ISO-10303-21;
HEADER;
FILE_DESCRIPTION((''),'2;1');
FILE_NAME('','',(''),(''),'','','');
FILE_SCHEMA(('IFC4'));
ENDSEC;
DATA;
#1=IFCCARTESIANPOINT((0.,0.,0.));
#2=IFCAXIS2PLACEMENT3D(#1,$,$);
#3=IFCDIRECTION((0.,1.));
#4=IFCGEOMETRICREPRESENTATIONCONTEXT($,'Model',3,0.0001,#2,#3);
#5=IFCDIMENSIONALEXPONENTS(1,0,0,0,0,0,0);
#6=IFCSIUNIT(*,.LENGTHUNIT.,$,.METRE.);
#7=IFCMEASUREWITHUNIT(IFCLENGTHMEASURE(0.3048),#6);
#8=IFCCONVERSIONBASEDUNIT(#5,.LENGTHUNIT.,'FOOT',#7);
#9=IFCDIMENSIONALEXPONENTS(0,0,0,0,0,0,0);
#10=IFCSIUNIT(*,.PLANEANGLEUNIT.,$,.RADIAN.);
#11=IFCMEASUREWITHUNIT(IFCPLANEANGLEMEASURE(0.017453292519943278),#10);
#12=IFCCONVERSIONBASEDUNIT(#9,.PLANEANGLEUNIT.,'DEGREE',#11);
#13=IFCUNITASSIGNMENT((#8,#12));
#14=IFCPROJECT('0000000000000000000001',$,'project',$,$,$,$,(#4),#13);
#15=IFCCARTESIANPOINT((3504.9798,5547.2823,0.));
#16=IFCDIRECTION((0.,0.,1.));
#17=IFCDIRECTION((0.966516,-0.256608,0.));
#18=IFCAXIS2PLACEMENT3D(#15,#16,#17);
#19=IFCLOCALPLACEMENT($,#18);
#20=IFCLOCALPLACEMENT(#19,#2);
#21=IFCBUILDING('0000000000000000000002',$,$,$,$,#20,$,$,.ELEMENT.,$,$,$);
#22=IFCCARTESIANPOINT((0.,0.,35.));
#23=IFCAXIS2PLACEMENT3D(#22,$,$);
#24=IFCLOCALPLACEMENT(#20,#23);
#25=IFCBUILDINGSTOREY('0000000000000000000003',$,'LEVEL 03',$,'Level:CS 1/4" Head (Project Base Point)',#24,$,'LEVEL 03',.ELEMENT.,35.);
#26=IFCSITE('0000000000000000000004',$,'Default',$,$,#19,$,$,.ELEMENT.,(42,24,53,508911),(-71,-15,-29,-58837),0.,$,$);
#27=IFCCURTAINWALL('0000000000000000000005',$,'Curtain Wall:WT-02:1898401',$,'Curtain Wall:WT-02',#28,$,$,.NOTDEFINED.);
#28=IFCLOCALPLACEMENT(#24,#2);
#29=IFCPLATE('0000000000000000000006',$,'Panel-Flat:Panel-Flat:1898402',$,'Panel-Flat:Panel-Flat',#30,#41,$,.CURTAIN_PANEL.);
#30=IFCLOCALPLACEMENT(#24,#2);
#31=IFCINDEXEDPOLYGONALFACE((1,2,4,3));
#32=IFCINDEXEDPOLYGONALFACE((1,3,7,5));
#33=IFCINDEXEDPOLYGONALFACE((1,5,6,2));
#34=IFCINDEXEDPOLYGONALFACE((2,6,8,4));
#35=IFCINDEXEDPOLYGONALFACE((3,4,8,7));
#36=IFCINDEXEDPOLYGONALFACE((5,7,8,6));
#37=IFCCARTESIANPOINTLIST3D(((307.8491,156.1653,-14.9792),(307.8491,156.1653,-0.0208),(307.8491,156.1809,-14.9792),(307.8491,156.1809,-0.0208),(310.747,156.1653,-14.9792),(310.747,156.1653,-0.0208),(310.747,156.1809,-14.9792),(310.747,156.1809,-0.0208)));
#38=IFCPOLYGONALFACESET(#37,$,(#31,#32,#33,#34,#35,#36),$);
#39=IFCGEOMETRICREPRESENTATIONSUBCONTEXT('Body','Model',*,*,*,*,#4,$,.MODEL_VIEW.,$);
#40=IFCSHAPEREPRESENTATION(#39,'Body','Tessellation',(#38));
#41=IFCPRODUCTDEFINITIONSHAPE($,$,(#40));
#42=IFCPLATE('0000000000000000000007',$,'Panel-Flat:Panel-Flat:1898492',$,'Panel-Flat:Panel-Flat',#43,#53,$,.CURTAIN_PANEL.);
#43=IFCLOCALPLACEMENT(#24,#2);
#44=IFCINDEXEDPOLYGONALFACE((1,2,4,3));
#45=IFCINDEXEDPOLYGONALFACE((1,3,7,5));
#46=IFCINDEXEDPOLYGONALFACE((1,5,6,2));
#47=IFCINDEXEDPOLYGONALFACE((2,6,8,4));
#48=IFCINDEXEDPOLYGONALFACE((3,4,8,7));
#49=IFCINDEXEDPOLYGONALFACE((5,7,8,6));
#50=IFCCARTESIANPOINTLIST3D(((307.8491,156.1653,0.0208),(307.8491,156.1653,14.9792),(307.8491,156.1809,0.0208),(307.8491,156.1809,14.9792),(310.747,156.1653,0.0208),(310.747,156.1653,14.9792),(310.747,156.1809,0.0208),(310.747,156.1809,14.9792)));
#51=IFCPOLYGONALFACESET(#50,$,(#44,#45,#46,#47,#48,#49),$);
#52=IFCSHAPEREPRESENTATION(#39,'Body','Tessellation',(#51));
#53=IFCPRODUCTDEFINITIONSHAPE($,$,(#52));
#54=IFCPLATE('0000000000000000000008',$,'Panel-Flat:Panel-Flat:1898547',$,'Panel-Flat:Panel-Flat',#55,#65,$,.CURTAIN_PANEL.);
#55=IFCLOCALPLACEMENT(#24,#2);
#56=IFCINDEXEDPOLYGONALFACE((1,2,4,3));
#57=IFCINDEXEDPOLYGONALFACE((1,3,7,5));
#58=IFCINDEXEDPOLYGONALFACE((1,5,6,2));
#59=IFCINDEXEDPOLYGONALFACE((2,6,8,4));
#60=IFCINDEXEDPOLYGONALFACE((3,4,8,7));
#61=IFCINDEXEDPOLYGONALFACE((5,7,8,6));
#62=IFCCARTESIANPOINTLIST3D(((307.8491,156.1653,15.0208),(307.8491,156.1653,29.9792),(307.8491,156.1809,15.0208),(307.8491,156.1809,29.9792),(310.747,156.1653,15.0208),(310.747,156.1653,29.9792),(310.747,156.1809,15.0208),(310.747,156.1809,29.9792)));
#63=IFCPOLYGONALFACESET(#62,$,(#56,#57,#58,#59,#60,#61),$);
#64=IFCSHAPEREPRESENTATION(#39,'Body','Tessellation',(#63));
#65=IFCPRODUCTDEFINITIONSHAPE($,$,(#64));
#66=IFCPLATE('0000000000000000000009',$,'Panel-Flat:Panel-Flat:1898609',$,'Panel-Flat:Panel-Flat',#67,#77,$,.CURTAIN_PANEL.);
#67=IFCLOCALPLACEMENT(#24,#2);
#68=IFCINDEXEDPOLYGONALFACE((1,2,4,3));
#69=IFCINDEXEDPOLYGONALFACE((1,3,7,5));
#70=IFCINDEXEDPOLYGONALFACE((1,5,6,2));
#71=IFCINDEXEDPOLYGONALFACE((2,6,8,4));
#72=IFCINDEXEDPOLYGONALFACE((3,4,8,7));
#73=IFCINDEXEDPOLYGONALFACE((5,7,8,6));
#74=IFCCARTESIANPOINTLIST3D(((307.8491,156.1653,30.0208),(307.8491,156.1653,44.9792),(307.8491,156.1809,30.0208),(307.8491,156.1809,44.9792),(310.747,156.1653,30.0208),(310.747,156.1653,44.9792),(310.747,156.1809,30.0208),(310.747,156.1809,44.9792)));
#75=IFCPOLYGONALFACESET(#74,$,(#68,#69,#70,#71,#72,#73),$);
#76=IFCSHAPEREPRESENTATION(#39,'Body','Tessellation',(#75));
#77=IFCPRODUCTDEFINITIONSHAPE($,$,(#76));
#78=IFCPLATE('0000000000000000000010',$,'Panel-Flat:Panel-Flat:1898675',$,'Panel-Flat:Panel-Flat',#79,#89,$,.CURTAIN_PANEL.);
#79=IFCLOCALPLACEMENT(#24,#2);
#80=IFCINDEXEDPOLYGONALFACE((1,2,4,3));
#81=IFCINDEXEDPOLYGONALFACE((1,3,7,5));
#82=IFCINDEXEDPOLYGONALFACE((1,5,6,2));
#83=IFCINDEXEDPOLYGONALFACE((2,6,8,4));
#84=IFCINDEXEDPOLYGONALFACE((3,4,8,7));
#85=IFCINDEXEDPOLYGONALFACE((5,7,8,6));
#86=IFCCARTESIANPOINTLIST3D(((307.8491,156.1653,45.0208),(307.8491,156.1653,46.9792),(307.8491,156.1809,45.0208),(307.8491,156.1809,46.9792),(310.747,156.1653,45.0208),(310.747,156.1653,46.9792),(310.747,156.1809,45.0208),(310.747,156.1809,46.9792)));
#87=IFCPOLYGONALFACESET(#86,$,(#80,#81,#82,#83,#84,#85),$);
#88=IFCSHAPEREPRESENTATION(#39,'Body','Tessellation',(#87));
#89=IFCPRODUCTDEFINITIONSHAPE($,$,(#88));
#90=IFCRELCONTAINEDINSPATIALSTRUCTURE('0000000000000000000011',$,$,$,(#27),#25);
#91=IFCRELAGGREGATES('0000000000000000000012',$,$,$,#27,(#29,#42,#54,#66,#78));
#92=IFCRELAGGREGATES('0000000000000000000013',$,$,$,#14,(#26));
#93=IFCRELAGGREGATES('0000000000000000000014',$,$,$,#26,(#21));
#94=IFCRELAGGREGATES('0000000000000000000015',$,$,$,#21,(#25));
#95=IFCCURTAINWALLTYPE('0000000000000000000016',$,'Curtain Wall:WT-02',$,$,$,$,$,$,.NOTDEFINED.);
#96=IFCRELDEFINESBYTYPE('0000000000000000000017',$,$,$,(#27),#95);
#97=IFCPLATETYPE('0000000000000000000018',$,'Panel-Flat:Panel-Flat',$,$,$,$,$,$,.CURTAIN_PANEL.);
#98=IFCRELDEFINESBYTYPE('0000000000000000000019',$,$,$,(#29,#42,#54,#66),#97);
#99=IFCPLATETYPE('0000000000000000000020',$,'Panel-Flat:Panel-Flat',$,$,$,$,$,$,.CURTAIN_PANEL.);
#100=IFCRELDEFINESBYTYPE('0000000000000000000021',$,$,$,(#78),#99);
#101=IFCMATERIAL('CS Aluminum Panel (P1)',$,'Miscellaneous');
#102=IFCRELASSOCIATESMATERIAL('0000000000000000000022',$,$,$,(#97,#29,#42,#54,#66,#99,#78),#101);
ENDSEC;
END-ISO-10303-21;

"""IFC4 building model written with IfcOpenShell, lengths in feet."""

from ifc_helpers import new_model, entity, si_unit, converted_unit, direction, frame, origin, place, context, subcontext, project, spatial, indexed_curve, outline, extrude, source, transform, mapped, material, type_object, type_shapes, element, aggregate, save


model = new_model("IFC4")

# Units and contexts
model_context = context("Model", 3, precision=0.0001, world=origin(), true_north=direction((0.0, 1.0)))
body_context = subcontext(model_context, "Body", "Model", "MODEL_VIEW")
ifc_project = project(units=[converted_unit("LENGTHUNIT", "FOOT", entity("IfcLengthMeasure", 0.3048), si_unit("LENGTHUNIT", "METRE"), dimensions=[1, 0, 0, 0, 0, 0, 0]), converted_unit("PLANEANGLEUNIT", "DEGREE", entity("IfcPlaneAngleMeasure", 0.017453292519943278), si_unit("PLANEANGLEUNIT", "RADIAN"), dimensions=[0, 0, 0, 0, 0, 0, 0])], contexts=[model_context])

# Site, building, storey
site_placement = place(None, frame((3504.9798, 5547.2823, 0.0), z_axis=(0.0, 0.0, 1.0), x_axis=(0.966516, -0.256608, 0.0)))
site = spatial("IfcSite", under=ifc_project, at=site_placement, Name="Default", CompositionType="ELEMENT", RefLatitude=(42, 24, 53, 508911), RefLongitude=(-71, -15, -29, -58837), RefElevation=0.0)
building_placement = place(site_placement, origin())
building = spatial("IfcBuilding", under=site, at=building_placement, CompositionType="ELEMENT")
storey_placement = place(building_placement, frame((0.0, 0.0, 35.0)))
storey = spatial("IfcBuildingStorey", under=building, at=storey_placement, Name="LEVEL 03", ObjectType="Level:CS 1/4\" Head (Project Base Point)", LongName="LEVEL 03", CompositionType="ELEMENT", Elevation=35.0)

# Curtain wall, plates
curtain_wall_type = type_object("IfcCurtainWallType", Name="Curtain Wall:WT-02", PredefinedType="NOTDEFINED")
curtain_wall_1_placement = place(storey_placement, frame((0.0, 0.0, -35.0)))
curtain_wall_1 = element("IfcCurtainWall", 1, at=curtain_wall_1_placement, inside=storey, type_object=curtain_wall_type, Name="Curtain Wall:WT-02:1898401", ObjectType="Curtain Wall:WT-02", PredefinedType="NOTDEFINED")
ifc_material_1 = material(Name="CS Aluminum Panel (P1)", Category="Miscellaneous")
plate_type_1 = type_object("IfcPlateType", Name="Panel-Flat:Panel-Flat", PredefinedType="CURTAIN_PANEL", material=ifc_material_1)
shared_shape_1 = source(origin(), body_context, "Body", "SweptSolid", [
    extrude(outline(indexed_curve([(-0.0078, -1.4489), (0.0078, -1.4489), (0.0078, 1.4489), (-0.0078, 1.4489), (-0.0078, -1.4489)], self_intersect=False)), frame((1.4489, 0.0078, 0.0), z_axis=(0.0, 0.0, 1.0), x_axis=(0.0, -1.0, 0.0)), (0.0, 0.0, 1.0), 14.9583),
])
type_shapes(plate_type_1, [shared_shape_1])
plate_1_placement = place(curtain_wall_1_placement, frame((310.747, 156.1809, 20.0208), z_axis=(0.0, 0.0, 1.0), x_axis=(-1.0, 0.0, 0.0)))
plate_1 = element("IfcPlate", 2, at=plate_1_placement, type_object=plate_type_1, material=ifc_material_1, Name="Panel-Flat:Panel-Flat:1898402", ObjectType="Panel-Flat:Panel-Flat", PredefinedType="CURTAIN_PANEL", context=body_context, shape_type="MappedRepresentation", body=[
    mapped(shared_shape_1, transform((0.0, 0.0, 0.0), scale=1.0)),
])
plate_2_placement = place(curtain_wall_1_placement, frame((310.747, 156.1809, 35.0208), z_axis=(0.0, 0.0, 1.0), x_axis=(-1.0, 0.0, 0.0)))
plate_2 = element("IfcPlate", 3, at=plate_2_placement, type_object=plate_type_1, material=ifc_material_1, Name="Panel-Flat:Panel-Flat:1898492", ObjectType="Panel-Flat:Panel-Flat", PredefinedType="CURTAIN_PANEL", context=body_context, shape_type="MappedRepresentation", body=[
    mapped(shared_shape_1, transform((0.0, 0.0, 0.0), scale=1.0)),
])
plate_3_placement = place(curtain_wall_1_placement, frame((310.747, 156.1809, 50.0208), z_axis=(0.0, 0.0, 1.0), x_axis=(-1.0, 0.0, 0.0)))
plate_3 = element("IfcPlate", 4, at=plate_3_placement, type_object=plate_type_1, material=ifc_material_1, Name="Panel-Flat:Panel-Flat:1898547", ObjectType="Panel-Flat:Panel-Flat", PredefinedType="CURTAIN_PANEL", context=body_context, shape_type="MappedRepresentation", body=[
    mapped(shared_shape_1, transform((0.0, 0.0, 0.0), scale=1.0)),
])
plate_4_placement = place(curtain_wall_1_placement, frame((310.747, 156.1809, 65.0208), z_axis=(0.0, 0.0, 1.0), x_axis=(-1.0, 0.0, 0.0)))
plate_4 = element("IfcPlate", 5, at=plate_4_placement, type_object=plate_type_1, material=ifc_material_1, Name="Panel-Flat:Panel-Flat:1898609", ObjectType="Panel-Flat:Panel-Flat", PredefinedType="CURTAIN_PANEL", context=body_context, shape_type="MappedRepresentation", body=[
    mapped(shared_shape_1, transform((0.0, 0.0, 0.0), scale=1.0)),
])
plate_type_2 = type_object("IfcPlateType", Name="Panel-Flat:Panel-Flat", PredefinedType="CURTAIN_PANEL", material=ifc_material_1)
shared_shape_2 = source(origin(), body_context, "Body", "SweptSolid", [
    extrude(outline(indexed_curve([(-0.0078, -1.4489), (0.0078, -1.4489), (0.0078, 1.4489), (-0.0078, 1.4489), (-0.0078, -1.4489)], self_intersect=False)), frame((1.4489, 0.0078, 0.0), z_axis=(0.0, 0.0, 1.0), x_axis=(0.0, -1.0, 0.0)), (0.0, 0.0, 1.0), 1.9583),
])
type_shapes(plate_type_2, [shared_shape_2])
plate_5_placement = place(curtain_wall_1_placement, frame((310.747, 156.1809, 80.0208), z_axis=(0.0, 0.0, 1.0), x_axis=(-1.0, 0.0, 0.0)))
plate_5 = element("IfcPlate", 6, at=plate_5_placement, type_object=plate_type_2, material=ifc_material_1, Name="Panel-Flat:Panel-Flat:1898675", ObjectType="Panel-Flat:Panel-Flat", PredefinedType="CURTAIN_PANEL", context=body_context, shape_type="MappedRepresentation", body=[
    mapped(shared_shape_2, transform((0.0, 0.0, 0.0), scale=1.0)),
])
aggregate(curtain_wall_1, [plate_1, plate_2, plate_3, plate_4, plate_5])

save(model, "model.ifc")
